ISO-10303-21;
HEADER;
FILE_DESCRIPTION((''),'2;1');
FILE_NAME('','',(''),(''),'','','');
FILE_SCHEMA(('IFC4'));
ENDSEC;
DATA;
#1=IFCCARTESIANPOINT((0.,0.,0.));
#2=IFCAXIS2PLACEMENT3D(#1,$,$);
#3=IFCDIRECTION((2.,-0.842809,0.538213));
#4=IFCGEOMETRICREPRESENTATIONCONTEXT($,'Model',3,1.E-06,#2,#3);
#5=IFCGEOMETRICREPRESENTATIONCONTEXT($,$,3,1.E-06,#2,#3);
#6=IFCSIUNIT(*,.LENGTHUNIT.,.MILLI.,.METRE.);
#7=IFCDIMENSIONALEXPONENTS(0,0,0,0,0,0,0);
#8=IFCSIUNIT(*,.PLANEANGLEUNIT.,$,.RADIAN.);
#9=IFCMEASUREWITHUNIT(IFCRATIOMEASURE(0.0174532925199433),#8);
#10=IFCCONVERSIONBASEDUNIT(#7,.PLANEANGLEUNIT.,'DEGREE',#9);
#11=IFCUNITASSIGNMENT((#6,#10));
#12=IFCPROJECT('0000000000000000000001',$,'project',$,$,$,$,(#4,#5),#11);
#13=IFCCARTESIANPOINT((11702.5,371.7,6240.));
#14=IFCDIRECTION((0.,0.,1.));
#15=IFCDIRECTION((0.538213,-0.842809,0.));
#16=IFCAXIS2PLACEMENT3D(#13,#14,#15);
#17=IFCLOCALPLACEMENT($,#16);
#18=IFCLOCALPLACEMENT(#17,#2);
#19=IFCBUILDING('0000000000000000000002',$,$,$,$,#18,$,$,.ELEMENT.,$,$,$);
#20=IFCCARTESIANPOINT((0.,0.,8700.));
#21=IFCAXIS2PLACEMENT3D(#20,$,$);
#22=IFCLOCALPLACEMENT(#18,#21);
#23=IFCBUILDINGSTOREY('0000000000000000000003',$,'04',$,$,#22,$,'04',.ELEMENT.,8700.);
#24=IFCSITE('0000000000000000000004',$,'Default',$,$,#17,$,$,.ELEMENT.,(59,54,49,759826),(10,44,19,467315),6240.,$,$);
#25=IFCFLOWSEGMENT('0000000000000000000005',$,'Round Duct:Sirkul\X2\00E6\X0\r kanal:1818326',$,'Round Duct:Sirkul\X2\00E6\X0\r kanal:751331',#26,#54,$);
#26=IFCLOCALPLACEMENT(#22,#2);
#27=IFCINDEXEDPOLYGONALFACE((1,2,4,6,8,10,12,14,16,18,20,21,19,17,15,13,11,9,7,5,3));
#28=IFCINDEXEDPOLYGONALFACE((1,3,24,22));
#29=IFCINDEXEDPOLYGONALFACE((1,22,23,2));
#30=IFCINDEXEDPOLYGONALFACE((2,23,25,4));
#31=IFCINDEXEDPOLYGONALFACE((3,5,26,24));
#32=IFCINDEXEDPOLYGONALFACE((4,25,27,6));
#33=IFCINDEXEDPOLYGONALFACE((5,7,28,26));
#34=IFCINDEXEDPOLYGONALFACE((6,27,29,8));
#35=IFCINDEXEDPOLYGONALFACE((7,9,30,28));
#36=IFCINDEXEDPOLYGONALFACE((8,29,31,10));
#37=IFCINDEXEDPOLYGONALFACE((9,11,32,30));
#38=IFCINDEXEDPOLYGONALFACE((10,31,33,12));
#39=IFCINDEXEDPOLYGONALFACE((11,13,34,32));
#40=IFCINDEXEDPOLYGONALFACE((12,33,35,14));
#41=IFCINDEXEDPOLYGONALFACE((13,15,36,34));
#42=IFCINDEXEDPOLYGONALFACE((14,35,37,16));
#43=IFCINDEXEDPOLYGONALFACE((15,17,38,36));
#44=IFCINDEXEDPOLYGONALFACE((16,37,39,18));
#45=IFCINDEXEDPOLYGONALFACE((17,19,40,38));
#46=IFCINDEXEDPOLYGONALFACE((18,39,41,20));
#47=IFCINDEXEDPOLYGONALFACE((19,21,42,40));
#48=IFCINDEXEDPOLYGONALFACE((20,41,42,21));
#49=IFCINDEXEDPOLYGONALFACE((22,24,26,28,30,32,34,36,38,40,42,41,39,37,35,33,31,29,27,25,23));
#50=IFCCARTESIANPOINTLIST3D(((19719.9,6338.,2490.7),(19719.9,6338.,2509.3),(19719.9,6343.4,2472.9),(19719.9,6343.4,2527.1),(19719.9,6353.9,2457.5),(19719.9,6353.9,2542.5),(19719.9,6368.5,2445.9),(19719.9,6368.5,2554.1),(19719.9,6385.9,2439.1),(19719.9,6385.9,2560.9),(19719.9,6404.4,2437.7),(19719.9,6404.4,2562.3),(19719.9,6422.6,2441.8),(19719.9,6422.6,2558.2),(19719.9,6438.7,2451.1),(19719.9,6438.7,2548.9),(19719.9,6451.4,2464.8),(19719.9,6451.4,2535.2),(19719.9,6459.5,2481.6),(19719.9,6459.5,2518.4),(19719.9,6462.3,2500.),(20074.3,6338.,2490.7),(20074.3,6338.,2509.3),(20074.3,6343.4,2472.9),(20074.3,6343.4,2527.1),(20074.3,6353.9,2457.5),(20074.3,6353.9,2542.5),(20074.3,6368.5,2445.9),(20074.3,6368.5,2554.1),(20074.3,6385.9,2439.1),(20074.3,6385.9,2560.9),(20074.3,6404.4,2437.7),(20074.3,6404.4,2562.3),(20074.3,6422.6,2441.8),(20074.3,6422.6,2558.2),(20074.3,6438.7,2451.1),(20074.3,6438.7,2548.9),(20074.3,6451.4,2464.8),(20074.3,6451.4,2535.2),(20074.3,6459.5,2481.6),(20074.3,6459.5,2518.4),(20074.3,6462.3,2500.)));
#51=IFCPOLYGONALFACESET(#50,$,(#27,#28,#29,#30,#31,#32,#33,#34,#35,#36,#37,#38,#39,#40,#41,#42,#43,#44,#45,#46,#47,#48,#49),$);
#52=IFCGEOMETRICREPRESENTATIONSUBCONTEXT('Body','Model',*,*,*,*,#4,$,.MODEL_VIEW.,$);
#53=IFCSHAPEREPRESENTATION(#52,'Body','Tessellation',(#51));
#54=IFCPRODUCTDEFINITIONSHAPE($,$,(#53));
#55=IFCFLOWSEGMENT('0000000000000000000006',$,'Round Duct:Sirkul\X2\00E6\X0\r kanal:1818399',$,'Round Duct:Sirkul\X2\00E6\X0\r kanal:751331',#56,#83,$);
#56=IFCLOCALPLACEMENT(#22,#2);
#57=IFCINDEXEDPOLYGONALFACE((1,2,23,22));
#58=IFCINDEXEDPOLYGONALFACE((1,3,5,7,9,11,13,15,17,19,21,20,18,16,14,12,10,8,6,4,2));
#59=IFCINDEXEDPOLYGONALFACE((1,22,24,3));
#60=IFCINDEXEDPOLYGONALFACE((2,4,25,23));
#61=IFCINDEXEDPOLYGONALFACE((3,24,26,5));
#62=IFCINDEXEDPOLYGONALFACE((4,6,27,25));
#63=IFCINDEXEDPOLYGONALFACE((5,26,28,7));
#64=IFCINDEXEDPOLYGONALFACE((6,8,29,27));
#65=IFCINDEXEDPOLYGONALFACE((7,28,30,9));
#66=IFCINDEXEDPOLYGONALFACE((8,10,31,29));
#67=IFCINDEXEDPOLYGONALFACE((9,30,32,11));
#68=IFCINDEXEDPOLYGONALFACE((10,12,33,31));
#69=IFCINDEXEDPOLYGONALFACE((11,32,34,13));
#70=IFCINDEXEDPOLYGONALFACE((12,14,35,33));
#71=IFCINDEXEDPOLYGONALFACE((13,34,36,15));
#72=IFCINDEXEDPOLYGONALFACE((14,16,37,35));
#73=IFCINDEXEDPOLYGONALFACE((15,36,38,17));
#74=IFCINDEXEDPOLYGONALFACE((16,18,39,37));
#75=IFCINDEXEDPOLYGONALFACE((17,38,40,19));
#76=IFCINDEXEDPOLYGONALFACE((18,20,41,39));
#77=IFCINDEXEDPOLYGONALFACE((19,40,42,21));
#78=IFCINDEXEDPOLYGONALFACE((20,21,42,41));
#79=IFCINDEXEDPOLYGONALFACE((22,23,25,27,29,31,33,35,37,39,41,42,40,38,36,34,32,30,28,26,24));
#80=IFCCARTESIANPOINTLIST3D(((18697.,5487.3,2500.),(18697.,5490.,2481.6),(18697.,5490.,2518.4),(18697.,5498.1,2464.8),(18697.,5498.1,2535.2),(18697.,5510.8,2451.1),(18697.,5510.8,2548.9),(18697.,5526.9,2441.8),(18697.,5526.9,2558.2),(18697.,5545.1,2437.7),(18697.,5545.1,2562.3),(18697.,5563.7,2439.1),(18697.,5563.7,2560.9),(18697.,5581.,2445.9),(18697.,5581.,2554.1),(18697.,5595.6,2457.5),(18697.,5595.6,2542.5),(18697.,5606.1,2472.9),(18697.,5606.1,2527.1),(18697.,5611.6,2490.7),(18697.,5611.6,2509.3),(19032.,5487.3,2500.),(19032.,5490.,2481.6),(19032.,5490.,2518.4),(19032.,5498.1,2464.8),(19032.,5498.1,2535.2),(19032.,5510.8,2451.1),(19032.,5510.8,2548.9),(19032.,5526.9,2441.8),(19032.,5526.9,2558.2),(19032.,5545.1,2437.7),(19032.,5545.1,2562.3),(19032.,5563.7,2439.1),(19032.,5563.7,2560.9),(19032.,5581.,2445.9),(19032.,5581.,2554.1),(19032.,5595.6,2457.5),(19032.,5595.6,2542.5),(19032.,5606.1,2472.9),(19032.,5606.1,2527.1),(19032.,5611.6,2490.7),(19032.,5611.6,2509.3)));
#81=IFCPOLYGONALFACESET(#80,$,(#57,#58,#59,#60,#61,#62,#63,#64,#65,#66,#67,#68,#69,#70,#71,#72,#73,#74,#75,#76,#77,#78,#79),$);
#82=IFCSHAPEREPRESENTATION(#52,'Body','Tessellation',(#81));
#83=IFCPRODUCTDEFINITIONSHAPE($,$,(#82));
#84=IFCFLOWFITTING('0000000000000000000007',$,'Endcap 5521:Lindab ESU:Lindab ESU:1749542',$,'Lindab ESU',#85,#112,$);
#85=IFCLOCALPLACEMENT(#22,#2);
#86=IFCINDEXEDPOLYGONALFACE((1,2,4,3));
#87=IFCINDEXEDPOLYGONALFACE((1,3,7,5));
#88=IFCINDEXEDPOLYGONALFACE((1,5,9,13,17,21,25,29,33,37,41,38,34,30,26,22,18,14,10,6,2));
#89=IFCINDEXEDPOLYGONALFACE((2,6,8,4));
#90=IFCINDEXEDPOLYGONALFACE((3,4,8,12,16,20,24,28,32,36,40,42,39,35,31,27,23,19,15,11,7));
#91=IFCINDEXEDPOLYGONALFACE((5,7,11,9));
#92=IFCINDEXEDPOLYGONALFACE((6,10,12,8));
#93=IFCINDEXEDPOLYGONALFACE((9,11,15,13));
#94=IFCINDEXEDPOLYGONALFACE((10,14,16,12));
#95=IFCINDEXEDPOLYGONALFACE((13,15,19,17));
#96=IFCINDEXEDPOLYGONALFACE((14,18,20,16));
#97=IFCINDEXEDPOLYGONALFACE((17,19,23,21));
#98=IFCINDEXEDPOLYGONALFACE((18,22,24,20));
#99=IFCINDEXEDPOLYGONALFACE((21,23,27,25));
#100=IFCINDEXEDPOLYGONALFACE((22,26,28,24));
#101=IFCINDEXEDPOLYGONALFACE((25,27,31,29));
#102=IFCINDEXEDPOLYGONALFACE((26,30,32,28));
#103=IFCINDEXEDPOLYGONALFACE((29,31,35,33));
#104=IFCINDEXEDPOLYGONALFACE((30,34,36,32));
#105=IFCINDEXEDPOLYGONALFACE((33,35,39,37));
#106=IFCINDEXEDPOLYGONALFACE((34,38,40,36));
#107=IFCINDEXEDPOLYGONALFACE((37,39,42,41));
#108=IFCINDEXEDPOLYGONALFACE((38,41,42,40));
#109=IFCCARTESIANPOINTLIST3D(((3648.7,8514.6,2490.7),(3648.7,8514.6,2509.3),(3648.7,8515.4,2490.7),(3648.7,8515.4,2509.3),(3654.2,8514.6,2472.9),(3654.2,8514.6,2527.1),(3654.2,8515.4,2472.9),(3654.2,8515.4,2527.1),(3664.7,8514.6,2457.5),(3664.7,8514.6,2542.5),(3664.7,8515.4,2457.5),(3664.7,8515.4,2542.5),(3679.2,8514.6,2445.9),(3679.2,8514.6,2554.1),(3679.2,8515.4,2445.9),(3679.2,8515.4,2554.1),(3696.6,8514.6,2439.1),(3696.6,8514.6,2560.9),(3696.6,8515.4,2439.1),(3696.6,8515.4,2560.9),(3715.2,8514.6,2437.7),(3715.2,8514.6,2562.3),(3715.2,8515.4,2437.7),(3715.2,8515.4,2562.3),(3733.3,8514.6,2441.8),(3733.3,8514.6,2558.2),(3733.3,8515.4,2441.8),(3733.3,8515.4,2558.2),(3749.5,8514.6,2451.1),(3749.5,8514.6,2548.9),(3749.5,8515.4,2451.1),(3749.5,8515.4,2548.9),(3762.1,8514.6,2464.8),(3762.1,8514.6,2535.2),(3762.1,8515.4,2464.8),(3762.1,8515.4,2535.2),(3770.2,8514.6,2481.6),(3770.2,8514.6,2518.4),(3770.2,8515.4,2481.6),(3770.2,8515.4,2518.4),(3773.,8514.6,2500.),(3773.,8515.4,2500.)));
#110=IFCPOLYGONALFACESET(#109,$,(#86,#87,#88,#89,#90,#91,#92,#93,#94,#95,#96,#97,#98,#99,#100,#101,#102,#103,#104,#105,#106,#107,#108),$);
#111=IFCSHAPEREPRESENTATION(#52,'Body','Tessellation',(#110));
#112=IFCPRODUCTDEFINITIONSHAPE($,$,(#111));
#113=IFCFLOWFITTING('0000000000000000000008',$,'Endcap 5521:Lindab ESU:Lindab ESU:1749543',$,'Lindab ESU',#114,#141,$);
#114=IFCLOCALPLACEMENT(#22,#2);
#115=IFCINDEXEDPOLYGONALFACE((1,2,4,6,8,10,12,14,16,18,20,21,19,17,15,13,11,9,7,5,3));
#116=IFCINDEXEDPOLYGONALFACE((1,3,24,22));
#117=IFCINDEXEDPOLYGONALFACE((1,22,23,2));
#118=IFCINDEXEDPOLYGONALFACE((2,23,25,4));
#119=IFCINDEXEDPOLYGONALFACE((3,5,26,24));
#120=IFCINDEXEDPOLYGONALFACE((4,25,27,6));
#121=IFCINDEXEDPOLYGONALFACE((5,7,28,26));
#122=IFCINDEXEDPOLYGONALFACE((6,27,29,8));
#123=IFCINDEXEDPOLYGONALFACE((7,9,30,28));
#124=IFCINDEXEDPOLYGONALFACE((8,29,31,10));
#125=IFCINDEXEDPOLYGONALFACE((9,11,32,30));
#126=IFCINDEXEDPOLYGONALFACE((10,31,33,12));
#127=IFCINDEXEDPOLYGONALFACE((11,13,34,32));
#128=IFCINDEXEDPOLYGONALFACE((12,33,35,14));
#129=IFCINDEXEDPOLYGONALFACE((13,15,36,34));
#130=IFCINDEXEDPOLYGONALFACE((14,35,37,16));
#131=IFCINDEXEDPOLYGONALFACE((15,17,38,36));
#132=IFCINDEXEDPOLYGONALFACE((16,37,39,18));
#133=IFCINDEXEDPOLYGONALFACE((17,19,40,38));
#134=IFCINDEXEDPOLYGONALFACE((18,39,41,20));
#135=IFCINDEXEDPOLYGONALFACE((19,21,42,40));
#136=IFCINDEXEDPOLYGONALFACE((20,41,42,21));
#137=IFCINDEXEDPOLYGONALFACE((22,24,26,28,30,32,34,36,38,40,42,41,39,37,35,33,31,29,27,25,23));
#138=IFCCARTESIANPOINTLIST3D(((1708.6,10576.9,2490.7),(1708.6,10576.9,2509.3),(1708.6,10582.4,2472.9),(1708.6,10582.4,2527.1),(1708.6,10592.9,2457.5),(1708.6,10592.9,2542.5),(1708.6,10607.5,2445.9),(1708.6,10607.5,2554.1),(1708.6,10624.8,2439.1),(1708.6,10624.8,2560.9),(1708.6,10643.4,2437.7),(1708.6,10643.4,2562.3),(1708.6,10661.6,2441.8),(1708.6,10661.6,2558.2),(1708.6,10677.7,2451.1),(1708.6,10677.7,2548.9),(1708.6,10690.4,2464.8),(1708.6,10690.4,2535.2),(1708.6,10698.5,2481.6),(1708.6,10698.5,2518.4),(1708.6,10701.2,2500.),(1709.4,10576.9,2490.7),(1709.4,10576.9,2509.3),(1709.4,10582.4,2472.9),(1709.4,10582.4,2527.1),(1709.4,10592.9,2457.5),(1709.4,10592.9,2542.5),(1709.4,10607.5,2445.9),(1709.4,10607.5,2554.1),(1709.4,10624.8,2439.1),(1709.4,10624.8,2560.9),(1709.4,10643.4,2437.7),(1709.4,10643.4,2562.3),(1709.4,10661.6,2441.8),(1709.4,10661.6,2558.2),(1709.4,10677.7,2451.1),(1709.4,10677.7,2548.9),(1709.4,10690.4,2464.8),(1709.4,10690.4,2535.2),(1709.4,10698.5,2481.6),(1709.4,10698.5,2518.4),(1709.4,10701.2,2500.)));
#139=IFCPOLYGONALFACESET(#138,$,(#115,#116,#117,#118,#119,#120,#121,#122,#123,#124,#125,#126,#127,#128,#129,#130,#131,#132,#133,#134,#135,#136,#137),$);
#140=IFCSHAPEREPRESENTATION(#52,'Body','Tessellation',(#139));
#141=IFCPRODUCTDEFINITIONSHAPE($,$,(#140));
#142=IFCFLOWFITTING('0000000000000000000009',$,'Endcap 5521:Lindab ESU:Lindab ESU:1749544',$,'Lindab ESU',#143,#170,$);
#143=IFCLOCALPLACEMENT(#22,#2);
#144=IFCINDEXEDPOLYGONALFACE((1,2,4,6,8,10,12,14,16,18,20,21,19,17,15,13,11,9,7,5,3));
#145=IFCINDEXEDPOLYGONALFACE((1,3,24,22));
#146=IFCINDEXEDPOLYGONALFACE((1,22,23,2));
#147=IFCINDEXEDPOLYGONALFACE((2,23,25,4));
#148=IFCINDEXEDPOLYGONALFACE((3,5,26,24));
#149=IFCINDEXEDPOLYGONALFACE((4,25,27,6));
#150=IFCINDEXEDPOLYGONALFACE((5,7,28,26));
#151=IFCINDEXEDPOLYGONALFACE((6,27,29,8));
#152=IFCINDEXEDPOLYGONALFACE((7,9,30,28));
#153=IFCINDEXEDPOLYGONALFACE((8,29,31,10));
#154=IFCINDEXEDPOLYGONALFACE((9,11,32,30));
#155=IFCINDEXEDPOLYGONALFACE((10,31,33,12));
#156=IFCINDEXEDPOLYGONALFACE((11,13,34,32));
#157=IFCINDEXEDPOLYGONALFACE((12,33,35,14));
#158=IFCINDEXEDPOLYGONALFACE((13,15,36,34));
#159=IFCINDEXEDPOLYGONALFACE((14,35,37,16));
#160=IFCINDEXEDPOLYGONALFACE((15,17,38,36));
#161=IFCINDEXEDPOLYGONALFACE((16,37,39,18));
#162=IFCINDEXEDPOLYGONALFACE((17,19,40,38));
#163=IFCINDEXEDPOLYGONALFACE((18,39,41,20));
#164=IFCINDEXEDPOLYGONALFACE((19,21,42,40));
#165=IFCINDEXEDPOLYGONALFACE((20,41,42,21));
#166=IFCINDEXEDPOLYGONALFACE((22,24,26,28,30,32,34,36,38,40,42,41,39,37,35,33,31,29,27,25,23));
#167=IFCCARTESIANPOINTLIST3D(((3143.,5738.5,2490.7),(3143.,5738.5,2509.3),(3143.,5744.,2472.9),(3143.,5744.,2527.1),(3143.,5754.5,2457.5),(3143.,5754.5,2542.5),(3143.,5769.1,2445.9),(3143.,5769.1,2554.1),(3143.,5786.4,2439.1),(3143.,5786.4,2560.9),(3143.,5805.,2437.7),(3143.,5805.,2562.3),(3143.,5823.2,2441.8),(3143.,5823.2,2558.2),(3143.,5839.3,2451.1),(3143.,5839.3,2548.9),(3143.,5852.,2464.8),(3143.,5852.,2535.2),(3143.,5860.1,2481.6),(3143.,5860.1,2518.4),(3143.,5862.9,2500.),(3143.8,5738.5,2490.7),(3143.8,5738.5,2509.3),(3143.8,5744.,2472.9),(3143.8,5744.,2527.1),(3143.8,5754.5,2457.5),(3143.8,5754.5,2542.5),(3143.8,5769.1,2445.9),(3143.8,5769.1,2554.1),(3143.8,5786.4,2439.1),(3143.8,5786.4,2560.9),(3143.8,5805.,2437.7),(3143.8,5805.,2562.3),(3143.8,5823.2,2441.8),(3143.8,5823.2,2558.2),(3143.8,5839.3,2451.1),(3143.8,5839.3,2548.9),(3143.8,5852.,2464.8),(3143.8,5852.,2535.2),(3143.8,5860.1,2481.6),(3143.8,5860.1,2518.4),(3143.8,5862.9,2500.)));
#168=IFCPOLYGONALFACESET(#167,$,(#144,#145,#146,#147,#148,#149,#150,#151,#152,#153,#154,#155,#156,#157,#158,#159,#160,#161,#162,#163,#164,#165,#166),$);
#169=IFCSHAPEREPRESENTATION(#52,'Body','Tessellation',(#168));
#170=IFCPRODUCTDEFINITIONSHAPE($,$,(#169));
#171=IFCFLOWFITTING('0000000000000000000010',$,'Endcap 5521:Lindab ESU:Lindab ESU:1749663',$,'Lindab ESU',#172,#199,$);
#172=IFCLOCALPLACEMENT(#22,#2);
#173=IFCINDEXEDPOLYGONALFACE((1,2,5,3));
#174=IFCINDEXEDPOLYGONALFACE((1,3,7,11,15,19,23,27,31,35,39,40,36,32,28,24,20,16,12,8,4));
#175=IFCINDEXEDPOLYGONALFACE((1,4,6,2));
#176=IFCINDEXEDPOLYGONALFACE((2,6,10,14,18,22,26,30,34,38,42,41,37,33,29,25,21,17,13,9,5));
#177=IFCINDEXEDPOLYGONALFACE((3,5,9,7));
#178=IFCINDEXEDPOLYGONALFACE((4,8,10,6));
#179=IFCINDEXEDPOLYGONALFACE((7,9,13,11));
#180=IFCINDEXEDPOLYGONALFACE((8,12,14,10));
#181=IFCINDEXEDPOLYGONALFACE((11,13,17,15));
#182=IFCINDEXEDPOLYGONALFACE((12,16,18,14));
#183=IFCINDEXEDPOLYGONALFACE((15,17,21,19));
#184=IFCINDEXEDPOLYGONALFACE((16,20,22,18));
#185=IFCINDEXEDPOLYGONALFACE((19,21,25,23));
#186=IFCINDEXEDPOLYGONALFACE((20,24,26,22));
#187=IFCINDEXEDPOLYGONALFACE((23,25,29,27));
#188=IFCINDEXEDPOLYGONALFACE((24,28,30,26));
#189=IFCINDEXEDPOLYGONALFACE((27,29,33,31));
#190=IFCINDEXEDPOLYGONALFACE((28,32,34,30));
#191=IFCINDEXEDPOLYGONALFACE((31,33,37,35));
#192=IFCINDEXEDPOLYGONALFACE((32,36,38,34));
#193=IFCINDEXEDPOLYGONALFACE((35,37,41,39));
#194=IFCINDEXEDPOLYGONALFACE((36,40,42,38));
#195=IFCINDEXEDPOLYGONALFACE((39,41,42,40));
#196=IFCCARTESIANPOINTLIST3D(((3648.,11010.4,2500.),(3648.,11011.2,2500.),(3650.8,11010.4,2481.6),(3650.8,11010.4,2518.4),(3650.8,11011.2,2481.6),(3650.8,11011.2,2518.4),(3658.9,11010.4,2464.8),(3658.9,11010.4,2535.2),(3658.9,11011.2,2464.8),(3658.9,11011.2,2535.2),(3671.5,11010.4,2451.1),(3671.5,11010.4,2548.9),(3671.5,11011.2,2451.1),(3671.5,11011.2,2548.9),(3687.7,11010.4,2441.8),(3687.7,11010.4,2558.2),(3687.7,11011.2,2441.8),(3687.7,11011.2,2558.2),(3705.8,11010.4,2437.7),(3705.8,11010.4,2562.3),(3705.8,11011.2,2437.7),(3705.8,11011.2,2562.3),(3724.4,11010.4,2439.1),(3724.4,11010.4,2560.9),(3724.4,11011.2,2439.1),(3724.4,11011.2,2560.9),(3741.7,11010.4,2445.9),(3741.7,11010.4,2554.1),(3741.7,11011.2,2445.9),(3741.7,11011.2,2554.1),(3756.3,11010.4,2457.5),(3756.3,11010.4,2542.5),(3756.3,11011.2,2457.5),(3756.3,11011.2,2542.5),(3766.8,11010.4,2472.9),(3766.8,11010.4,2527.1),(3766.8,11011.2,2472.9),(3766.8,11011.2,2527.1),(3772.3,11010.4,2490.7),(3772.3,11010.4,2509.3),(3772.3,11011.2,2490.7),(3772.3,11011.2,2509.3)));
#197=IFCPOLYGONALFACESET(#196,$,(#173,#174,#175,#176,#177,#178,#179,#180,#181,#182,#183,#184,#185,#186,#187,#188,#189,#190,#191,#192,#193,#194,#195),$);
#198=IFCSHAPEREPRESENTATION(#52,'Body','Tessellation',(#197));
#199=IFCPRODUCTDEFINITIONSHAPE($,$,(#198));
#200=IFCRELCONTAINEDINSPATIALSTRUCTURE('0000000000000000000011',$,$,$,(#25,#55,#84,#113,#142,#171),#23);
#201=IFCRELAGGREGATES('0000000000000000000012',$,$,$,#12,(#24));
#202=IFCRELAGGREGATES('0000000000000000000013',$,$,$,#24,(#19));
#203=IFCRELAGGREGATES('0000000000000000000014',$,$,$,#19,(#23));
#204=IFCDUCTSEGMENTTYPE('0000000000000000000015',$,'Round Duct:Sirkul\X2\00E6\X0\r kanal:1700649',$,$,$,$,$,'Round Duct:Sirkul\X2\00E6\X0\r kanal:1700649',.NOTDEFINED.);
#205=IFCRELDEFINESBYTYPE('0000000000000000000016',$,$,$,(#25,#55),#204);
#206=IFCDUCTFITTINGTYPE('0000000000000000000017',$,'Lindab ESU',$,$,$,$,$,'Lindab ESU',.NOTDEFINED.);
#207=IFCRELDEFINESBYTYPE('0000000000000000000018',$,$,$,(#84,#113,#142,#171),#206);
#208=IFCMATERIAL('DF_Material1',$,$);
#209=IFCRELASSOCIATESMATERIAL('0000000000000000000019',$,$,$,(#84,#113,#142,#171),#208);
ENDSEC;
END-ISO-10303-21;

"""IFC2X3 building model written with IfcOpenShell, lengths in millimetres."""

from ifc_helpers import new_model, entity, si_unit, converted_unit, direction, frame, frame_2d, origin, origin_2d_with_axis, place, context, subcontext, project, spatial, circle, extrude, source, transform, mapped, material, type_object, type_shapes, element, save


model = new_model("IFC2X3")

# Units and contexts
model_context = context("Model", 3, precision=1e-06, world=origin(), true_north=direction((2.0, -0.842809, 0.538213)))
context_of_model = context(None, 3, precision=1e-06, world=origin(), true_north=direction((2.0, -0.842809, 0.538213)))
body_context = subcontext(model_context, "Body", "Model", "MODEL_VIEW")
ifc_project = project(units=[si_unit("LENGTHUNIT", "METRE", prefix="MILLI"), converted_unit("PLANEANGLEUNIT", "DEGREE", entity("IfcRatioMeasure", 0.0174532925199433), si_unit("PLANEANGLEUNIT", "RADIAN"), dimensions=[0, 0, 0, 0, 0, 0, 0])], contexts=[model_context, context_of_model])

# Site, building, storey
site_placement = place(None, frame((11702.5, 371.7, 6240.0), z_axis=(0.0, 0.0, 1.0), x_axis=(0.538213, -0.842809, 0.0)))
site = spatial("IfcSite", under=ifc_project, at=site_placement, Name="Default", CompositionType="ELEMENT", RefLatitude=(59, 54, 49, 759826), RefLongitude=(10, 44, 19, 467315), RefElevation=6240.0)
building_placement = place(site_placement, origin())
building = spatial("IfcBuilding", under=site, at=building_placement, CompositionType="ELEMENT")
storey_placement = place(building_placement, frame((0.0, 0.0, 8700.0)))
storey = spatial("IfcBuildingStorey", under=building, at=storey_placement, Name="04", LongName="04", CompositionType="ELEMENT", Elevation=8700.0)

# Flow segments
duct_segment_type_1 = type_object("IfcDuctSegmentType", Name="Round Duct:Sirkulær kanal:1700649", ElementType="Round Duct:Sirkulær kanal:1700649", PredefinedType="NOTDEFINED")
flow_segment_1_placement = place(storey_placement, origin())
element("IfcFlowSegment", 1, at=flow_segment_1_placement, inside=storey, type_object=duct_segment_type_1, Name="Round Duct:Sirkulær kanal:1818326", ObjectType="Round Duct:Sirkulær kanal:751331", context=body_context, shape_type="SweptSolid", body=[
    extrude(circle(Radius=62.5, at=frame_2d((0.0, 0.0), x_axis=(1.0, 0.0))), frame((19719.9, 6399.8, 2500.0), z_axis=(1.0, 0.0, 0.0), x_axis=(0.0, 1.0, 0.0)), (0.0, 0.0, 1.0), 354.5),
])
flow_segment_2_placement = place(storey_placement, origin())
element("IfcFlowSegment", 2, at=flow_segment_2_placement, inside=storey, type_object=duct_segment_type_1, Name="Round Duct:Sirkulær kanal:1818399", ObjectType="Round Duct:Sirkulær kanal:751331", context=body_context, shape_type="SweptSolid", body=[
    extrude(circle(Radius=62.5, at=origin_2d_with_axis()), frame((18697.0, 5549.8, 2500.0), z_axis=(1.0, 0.0, 0.0), x_axis=(0.0, -1.0, 0.0)), (0.0, 0.0, 1.0), 335.0),
])

# Flow fittings
ifc_material = material(Name="DF_Material1")
duct_fitting_type = type_object("IfcDuctFittingType", Name="Lindab ESU", ElementType="Lindab ESU", PredefinedType="NOTDEFINED")
shared_shape_1 = source(origin(), body_context, "Body", "SweptSolid", [
    extrude(circle(Radius=62.5, at=frame_2d((0.0, 0.0), x_axis=(1.0, 0.0))), frame((0.0, 0.0, 0.0), z_axis=(1.0, 0.0, 0.0), x_axis=(0.0, 1.0, 0.0)), (0.0, 0.0, 1.0), 0.8),
])
type_shapes(duct_fitting_type, [shared_shape_1])
flow_fitting_1_placement = place(storey_placement, frame((3710.5, 8515.4, 2500.0), z_axis=(0.0, 0.0, 1.0), x_axis=(0.0, -1.0, 0.0)))
element("IfcFlowFitting", 3, at=flow_fitting_1_placement, inside=storey, type_object=duct_fitting_type, material=ifc_material, Name="Endcap 5521:Lindab ESU:Lindab ESU:1749542", ObjectType="Lindab ESU", context=body_context, shape_type="MappedRepresentation", body=[
    mapped(shared_shape_1, transform((0.0, 0.0, 0.0), scale=1.0)),
])
for number, where, name in (
    (4, (1708.6, 10638.7, 2500.0), "Endcap 5521:Lindab ESU:Lindab ESU:1749543"),
    (5, (3143.0, 5800.4, 2500.0), "Endcap 5521:Lindab ESU:Lindab ESU:1749544"),
):
    element("IfcFlowFitting", number, at=place(storey_placement, frame(where)), inside=storey, type_object=duct_fitting_type, material=ifc_material, Name=name, ObjectType="Lindab ESU", context=body_context, shape_type="MappedRepresentation", body=[
        mapped(shared_shape_1, transform((0.0, 0.0, 0.0), scale=1.0)),
    ])
flow_fitting_2_placement = place(storey_placement, frame((3710.5, 11010.4, 2500.0), z_axis=(0.0, 0.0, 1.0), x_axis=(0.0, 1.0, 0.0)))
element("IfcFlowFitting", 6, at=flow_fitting_2_placement, inside=storey, type_object=duct_fitting_type, material=ifc_material, Name="Endcap 5521:Lindab ESU:Lindab ESU:1749663", ObjectType="Lindab ESU", context=body_context, shape_type="MappedRepresentation", body=[
    mapped(shared_shape_1, transform((0.0, 0.0, 0.0), scale=1.0)),
])

save(model, "model.ifc")
